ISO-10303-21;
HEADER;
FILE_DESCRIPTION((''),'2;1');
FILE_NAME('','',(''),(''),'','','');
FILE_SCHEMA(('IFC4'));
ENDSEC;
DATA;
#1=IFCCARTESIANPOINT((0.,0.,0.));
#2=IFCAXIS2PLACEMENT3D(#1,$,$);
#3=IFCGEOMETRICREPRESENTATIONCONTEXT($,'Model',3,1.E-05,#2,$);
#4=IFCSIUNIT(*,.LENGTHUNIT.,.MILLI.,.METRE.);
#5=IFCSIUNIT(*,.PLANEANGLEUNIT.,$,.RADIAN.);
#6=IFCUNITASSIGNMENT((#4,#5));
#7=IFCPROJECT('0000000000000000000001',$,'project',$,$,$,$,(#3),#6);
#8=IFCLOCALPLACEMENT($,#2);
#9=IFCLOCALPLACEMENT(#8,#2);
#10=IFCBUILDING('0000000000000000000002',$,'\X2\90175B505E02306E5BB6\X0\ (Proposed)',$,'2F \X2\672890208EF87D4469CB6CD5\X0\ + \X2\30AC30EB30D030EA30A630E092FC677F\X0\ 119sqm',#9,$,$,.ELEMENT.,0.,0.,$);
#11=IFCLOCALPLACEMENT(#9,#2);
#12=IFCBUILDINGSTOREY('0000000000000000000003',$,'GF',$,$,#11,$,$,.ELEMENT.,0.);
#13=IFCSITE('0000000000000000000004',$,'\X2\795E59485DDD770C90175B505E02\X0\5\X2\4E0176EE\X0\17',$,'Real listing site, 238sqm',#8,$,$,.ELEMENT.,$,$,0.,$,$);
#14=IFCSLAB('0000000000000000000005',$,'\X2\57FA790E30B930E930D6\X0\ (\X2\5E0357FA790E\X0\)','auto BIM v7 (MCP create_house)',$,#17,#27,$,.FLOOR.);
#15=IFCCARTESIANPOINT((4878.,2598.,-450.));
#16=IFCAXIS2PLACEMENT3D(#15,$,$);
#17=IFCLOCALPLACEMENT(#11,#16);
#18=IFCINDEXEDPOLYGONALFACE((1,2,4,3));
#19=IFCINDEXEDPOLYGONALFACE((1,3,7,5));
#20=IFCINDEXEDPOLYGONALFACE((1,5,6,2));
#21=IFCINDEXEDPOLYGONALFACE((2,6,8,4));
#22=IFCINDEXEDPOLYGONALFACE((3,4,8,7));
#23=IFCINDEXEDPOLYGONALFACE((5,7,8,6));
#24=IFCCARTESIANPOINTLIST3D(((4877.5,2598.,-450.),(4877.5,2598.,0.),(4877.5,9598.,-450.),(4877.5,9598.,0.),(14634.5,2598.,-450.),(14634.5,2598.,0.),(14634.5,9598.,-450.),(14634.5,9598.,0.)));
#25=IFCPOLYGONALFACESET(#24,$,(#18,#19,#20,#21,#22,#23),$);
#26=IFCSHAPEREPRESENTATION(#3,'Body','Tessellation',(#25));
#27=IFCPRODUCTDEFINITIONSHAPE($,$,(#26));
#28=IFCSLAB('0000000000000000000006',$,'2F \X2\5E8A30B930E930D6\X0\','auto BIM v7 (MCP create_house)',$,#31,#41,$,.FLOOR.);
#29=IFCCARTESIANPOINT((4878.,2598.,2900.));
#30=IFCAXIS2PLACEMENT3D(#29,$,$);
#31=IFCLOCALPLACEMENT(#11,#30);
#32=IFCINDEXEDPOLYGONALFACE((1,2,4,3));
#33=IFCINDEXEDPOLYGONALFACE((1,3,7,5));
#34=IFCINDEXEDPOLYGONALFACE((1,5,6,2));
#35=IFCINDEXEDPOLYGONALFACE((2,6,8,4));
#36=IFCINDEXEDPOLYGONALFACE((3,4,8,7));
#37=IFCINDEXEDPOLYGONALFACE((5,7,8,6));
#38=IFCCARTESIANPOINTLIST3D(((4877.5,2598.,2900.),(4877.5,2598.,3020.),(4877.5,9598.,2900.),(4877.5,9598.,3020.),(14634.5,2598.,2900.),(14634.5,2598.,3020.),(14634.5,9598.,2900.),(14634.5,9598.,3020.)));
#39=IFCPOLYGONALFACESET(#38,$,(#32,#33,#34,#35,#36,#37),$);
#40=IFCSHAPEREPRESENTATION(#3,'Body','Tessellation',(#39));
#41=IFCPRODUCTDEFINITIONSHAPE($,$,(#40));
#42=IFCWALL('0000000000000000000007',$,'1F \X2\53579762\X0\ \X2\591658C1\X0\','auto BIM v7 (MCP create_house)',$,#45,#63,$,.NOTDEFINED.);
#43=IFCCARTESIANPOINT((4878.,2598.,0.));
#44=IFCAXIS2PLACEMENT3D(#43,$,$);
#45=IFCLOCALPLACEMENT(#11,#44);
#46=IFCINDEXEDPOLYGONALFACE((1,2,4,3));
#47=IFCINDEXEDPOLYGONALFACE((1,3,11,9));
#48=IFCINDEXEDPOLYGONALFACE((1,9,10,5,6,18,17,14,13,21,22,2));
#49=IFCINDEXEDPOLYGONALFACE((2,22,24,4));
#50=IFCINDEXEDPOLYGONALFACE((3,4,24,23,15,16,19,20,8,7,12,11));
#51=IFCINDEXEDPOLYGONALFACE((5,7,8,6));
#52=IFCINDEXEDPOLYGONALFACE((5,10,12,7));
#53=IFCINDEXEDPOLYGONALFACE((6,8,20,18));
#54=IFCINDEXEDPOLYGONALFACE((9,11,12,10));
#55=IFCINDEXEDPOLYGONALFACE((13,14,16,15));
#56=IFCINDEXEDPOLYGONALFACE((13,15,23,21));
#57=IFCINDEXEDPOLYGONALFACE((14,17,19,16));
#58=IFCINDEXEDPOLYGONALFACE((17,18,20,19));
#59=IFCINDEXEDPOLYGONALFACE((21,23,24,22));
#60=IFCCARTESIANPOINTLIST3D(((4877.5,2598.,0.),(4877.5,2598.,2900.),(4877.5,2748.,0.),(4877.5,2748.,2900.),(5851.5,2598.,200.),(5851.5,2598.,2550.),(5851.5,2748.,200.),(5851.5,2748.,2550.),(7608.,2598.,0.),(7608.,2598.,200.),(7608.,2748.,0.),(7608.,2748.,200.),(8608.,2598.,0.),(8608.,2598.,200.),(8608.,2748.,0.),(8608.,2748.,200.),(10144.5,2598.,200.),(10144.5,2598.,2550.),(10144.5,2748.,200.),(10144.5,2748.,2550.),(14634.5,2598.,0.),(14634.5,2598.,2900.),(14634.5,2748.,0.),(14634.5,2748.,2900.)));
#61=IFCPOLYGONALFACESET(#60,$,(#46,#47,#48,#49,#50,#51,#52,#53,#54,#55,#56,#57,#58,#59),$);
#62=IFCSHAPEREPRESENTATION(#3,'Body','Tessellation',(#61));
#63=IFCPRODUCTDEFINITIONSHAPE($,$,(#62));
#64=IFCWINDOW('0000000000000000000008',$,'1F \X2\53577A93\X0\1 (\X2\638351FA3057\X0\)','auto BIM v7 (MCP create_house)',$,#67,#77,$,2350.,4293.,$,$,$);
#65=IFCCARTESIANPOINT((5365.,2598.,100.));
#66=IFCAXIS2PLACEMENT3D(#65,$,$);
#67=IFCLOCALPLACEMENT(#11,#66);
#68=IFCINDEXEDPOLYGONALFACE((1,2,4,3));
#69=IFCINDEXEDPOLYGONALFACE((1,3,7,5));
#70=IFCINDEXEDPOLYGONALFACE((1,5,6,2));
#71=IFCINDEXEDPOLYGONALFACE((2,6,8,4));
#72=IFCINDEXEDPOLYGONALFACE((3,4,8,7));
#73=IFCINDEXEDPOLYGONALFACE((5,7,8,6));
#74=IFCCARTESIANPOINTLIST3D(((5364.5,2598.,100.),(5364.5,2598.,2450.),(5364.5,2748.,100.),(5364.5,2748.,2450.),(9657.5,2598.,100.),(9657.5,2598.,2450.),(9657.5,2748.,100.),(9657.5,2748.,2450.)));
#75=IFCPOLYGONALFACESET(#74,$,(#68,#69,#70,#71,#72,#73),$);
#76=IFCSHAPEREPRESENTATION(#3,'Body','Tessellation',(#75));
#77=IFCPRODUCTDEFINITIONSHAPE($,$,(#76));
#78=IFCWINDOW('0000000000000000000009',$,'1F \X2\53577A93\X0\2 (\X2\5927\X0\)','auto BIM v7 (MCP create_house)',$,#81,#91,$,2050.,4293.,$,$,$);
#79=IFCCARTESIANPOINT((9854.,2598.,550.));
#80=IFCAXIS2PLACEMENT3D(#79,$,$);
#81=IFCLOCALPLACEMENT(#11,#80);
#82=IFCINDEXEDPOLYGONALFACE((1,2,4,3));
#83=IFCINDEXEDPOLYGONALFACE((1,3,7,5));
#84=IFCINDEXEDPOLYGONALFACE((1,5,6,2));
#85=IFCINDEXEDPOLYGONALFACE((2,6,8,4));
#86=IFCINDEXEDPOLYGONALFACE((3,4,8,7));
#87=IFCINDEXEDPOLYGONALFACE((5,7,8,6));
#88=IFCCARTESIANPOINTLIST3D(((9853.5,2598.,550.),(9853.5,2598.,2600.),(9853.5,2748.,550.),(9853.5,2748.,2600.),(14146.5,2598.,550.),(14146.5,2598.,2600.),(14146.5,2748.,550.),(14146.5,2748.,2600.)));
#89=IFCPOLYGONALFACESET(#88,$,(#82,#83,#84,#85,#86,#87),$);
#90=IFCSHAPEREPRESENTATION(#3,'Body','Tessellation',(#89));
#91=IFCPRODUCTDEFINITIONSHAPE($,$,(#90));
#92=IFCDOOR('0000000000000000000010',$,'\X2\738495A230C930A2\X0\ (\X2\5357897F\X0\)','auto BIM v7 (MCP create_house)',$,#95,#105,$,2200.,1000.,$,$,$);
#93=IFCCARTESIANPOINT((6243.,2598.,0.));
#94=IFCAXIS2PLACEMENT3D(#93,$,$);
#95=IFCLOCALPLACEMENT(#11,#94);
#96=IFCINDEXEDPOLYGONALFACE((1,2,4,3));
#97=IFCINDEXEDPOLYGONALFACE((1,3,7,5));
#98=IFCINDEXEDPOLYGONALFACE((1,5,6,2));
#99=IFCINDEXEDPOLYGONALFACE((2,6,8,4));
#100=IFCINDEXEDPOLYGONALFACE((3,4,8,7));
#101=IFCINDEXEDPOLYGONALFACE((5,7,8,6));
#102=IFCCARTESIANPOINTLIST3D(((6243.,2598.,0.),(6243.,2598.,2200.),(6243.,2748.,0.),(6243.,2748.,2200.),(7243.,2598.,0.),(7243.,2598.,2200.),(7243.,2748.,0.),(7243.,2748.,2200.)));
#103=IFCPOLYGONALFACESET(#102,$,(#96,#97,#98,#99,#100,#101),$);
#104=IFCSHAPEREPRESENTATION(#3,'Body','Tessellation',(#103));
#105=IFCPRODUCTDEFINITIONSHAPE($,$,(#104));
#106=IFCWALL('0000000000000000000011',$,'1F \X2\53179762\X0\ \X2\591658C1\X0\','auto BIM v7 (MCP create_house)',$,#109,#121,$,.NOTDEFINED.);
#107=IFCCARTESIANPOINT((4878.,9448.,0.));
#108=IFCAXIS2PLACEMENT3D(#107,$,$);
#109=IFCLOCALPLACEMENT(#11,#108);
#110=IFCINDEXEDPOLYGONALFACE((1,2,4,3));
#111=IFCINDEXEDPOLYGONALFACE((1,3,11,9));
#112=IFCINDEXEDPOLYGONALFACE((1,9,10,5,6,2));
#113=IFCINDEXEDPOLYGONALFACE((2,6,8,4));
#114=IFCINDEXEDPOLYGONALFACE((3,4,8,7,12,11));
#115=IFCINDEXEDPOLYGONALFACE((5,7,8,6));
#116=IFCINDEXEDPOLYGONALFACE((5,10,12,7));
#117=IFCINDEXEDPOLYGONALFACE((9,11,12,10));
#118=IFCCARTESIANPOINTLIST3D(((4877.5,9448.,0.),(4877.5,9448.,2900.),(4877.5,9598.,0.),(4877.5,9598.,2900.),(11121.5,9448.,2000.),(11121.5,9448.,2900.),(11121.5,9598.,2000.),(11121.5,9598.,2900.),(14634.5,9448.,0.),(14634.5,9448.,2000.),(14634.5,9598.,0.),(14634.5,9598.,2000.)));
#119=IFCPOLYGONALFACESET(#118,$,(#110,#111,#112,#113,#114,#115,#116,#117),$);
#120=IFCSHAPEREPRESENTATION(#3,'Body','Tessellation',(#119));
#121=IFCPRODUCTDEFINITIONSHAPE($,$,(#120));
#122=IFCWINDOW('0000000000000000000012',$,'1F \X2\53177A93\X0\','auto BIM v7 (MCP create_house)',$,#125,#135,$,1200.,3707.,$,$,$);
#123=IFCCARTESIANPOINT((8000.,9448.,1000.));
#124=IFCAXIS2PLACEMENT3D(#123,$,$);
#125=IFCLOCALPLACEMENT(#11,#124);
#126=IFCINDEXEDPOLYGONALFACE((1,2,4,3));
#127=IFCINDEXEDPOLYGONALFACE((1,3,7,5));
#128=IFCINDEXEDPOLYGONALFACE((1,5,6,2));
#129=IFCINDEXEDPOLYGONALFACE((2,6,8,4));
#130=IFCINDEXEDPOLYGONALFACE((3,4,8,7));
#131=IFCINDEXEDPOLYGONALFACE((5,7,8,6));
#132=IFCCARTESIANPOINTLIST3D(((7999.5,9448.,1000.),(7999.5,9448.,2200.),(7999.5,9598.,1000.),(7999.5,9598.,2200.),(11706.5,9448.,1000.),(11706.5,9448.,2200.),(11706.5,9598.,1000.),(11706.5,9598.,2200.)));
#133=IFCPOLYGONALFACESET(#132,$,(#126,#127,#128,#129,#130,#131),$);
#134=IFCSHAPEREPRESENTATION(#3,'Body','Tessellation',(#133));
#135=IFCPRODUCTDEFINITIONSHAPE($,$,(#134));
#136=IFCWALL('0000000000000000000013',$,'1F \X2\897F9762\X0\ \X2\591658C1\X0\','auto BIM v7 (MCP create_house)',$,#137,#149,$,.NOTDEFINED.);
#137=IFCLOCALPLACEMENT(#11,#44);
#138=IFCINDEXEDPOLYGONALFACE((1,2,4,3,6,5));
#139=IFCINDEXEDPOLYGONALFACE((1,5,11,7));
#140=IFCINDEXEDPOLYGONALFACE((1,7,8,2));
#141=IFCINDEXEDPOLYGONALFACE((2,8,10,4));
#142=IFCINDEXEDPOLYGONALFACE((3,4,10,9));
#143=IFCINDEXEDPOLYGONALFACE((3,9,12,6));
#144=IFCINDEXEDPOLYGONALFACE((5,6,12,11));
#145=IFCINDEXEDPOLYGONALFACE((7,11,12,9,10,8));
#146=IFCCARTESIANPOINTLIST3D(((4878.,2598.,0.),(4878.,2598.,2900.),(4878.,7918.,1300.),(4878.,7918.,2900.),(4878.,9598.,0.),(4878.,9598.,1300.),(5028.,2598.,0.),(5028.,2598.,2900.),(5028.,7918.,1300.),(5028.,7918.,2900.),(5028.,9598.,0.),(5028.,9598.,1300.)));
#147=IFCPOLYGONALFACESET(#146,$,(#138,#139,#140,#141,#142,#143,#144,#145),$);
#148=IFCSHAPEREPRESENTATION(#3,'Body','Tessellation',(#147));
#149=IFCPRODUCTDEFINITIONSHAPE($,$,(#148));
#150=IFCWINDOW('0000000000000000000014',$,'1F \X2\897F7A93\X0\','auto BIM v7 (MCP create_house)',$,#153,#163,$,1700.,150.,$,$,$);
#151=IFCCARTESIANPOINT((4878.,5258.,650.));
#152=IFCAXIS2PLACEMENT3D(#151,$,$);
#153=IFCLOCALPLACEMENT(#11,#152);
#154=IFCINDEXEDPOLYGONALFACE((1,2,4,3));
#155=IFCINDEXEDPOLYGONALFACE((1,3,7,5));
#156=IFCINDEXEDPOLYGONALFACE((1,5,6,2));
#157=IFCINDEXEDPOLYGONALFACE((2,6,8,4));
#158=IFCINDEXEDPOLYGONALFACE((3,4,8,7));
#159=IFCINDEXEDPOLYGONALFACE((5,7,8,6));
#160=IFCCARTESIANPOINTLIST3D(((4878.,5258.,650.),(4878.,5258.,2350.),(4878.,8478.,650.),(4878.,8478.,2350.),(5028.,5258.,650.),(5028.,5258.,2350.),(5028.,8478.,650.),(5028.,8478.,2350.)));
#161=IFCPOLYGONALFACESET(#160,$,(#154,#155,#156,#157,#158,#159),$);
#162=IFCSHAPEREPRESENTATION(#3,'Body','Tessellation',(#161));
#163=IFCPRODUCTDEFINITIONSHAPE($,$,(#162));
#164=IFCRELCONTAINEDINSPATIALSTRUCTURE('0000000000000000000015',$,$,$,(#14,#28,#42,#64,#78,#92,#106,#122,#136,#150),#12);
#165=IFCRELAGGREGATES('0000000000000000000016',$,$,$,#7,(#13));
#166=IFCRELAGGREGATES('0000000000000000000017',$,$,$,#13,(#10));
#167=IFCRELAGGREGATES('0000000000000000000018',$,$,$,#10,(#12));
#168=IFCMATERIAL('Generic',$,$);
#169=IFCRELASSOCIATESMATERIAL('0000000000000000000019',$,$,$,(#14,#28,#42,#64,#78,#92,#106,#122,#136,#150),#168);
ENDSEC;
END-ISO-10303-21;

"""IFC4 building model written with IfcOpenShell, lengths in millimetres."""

from ifc_helpers import new_model, si_unit, frame, frame_2d, origin, place, context, project, spatial, rectangle, extrude, material, element, fill, save


model = new_model("IFC4")

# Units and contexts
model_context = context("Model", 3, precision=1e-05, world=origin())
ifc_project = project(units=[si_unit("LENGTHUNIT", "METRE", prefix="MILLI"), si_unit("PLANEANGLEUNIT", "RADIAN")], contexts=[model_context])

# Site, building, storey
site_placement = place(None, origin())
site = spatial("IfcSite", under=ifc_project, at=site_placement, Name="神奈川県逗子市5丁目17", ObjectType="Real listing site, 238sqm", CompositionType="ELEMENT", RefElevation=0.0)
building_placement = place(site_placement, origin())
building = spatial("IfcBuilding", under=site, at=building_placement, Name="逗子市の家 (Proposed)", ObjectType="2F 木造軸組構法 + ガルバリウム鋼板 119sqm", CompositionType="ELEMENT", ElevationOfRefHeight=0.0, ElevationOfTerrain=0.0)
storey_placement = place(building_placement, origin())
storey = spatial("IfcBuildingStorey", under=building, at=storey_placement, Name="GF", CompositionType="ELEMENT", Elevation=0.0)

# Slabs
ifc_material = material(Name="Generic")
slab_1_placement = place(storey_placement, frame((4878.0, 2598.0, -450.0)))
element("IfcSlab", 1, at=slab_1_placement, inside=storey, material=ifc_material, Name="基礎スラブ (布基礎)", Description="auto BIM v7 (MCP create_house)", PredefinedType="FLOOR", context=model_context, shape_type="SweptSolid", body=[
    extrude(rectangle(XDim=9757.0, YDim=7000.0, at=frame_2d((4878.0, 3500.0))), frame((4878.0, 2598.0, -450.0)), (0.0, 0.0, 1.0), 450.0),
])
slab_2_placement = place(storey_placement, frame((4878.0, 2598.0, 2900.0)))
element("IfcSlab", 2, at=slab_2_placement, inside=storey, material=ifc_material, Name="2F 床スラブ", Description="auto BIM v7 (MCP create_house)", PredefinedType="FLOOR", context=model_context, shape_type="SweptSolid", body=[
    extrude(rectangle(XDim=9757.0, YDim=7000.0, at=frame_2d((4878.0, 3500.0))), frame((4878.0, 2598.0, 2900.0)), (0.0, 0.0, 1.0), 120.0),
])

# Wall, openings, windows, door
wall_1_placement = place(storey_placement, frame((4878.0, 2598.0, 0.0)))
wall_1 = element("IfcWall", 3, at=wall_1_placement, inside=storey, material=ifc_material, Name="1F 南面 外壁", Description="auto BIM v7 (MCP create_house)", PredefinedType="NOTDEFINED", context=model_context, shape_type="SweptSolid", body=[
    extrude(rectangle(XDim=9757.0, YDim=150.0, at=frame_2d((4878.0, 75.0))), frame((4878.0, 2598.0, 0.0)), (0.0, 0.0, 1.0), 2900.0),
])
opening_1_placement = place(storey_placement, frame((5365.0, 2598.0, 100.0)))
opening_1 = element("IfcOpeningElement", 4, at=opening_1_placement, cuts=wall_1, PredefinedType="NOTDEFINED", context=model_context, shape_type="SweptSolid", body=[
    extrude(rectangle(XDim=4293.0, YDim=150.0, at=frame_2d((2146.0, 75.0))), frame((5365.0, 2598.0, 100.0)), (0.0, 0.0, 1.0), 2350.0),
])
opening_2_placement = place(storey_placement, frame((9854.0, 2598.0, 550.0)))
opening_2 = element("IfcOpeningElement", 5, at=opening_2_placement, cuts=wall_1, PredefinedType="NOTDEFINED", context=model_context, shape_type="SweptSolid", body=[
    extrude(rectangle(XDim=4293.0, YDim=150.0, at=frame_2d((2146.0, 75.0))), frame((9854.0, 2598.0, 550.0)), (0.0, 0.0, 1.0), 2050.0),
])
opening_3_placement = place(storey_placement, frame((6243.0, 2598.0, 0.0)))
opening_3 = element("IfcOpeningElement", 6, at=opening_3_placement, cuts=wall_1, PredefinedType="NOTDEFINED", context=model_context, shape_type="SweptSolid", body=[
    extrude(rectangle(XDim=1000.0, YDim=150.0, at=frame_2d((500.0, 75.0))), frame((6243.0, 2598.0, 0.0)), (0.0, 0.0, 1.0), 2200.0),
])
window_1_placement = place(storey_placement, frame((5365.0, 2598.0, 100.0)))
window_1 = element("IfcWindow", 7, at=window_1_placement, inside=storey, material=ifc_material, Name="1F 南窓1 (掃出し)", Description="auto BIM v7 (MCP create_house)", OverallHeight=2350.0, OverallWidth=4293.0, context=model_context, shape_type="SweptSolid", body=[
    extrude(rectangle(XDim=4293.0, YDim=150.0, at=frame_2d((2146.0, 75.0))), frame((5365.0, 2598.0, 100.0)), (0.0, 0.0, 1.0), 2350.0),
])
fill(opening_1, window_1)
window_2_placement = place(storey_placement, frame((9854.0, 2598.0, 550.0)))
window_2 = element("IfcWindow", 8, at=window_2_placement, inside=storey, material=ifc_material, Name="1F 南窓2 (大)", Description="auto BIM v7 (MCP create_house)", OverallHeight=2050.0, OverallWidth=4293.0, context=model_context, shape_type="SweptSolid", body=[
    extrude(rectangle(XDim=4293.0, YDim=150.0, at=frame_2d((2146.0, 75.0))), frame((9854.0, 2598.0, 550.0)), (0.0, 0.0, 1.0), 2050.0),
])
fill(opening_2, window_2)
door_placement = place(storey_placement, frame((6243.0, 2598.0, 0.0)))
door = element("IfcDoor", 9, at=door_placement, inside=storey, material=ifc_material, Name="玄関ドア (南西)", Description="auto BIM v7 (MCP create_house)", OverallHeight=2200.0, OverallWidth=1000.0, context=model_context, shape_type="SweptSolid", body=[
    extrude(rectangle(XDim=1000.0, YDim=150.0, at=frame_2d((500.0, 75.0))), frame((6243.0, 2598.0, 0.0)), (0.0, 0.0, 1.0), 2200.0),
])
fill(opening_3, door)

# Walls, openings, windows
wall_2_placement = place(storey_placement, frame((4878.0, 9448.0, 0.0)))
wall_2 = element("IfcWall", 10, at=wall_2_placement, inside=storey, material=ifc_material, Name="1F 北面 外壁", Description="auto BIM v7 (MCP create_house)", PredefinedType="NOTDEFINED", context=model_context, shape_type="SweptSolid", body=[
    extrude(rectangle(XDim=9757.0, YDim=150.0, at=frame_2d((4878.0, 75.0))), frame((4878.0, 9448.0, 0.0)), (0.0, 0.0, 1.0), 2900.0),
])
opening_4_placement = place(storey_placement, frame((8000.0, 9448.0, 1000.0)))
opening_4 = element("IfcOpeningElement", 11, at=opening_4_placement, cuts=wall_2, PredefinedType="NOTDEFINED", context=model_context, shape_type="SweptSolid", body=[
    extrude(rectangle(XDim=3707.0, YDim=150.0, at=frame_2d((1853.0, 75.0))), frame((8000.0, 9448.0, 1000.0)), (0.0, 0.0, 1.0), 1200.0),
])
window_3_placement = place(storey_placement, frame((8000.0, 9448.0, 1000.0)))
window_3 = element("IfcWindow", 12, at=window_3_placement, inside=storey, material=ifc_material, Name="1F 北窓", Description="auto BIM v7 (MCP create_house)", OverallHeight=1200.0, OverallWidth=3707.0, context=model_context, shape_type="SweptSolid", body=[
    extrude(rectangle(XDim=3707.0, YDim=150.0, at=frame_2d((1853.0, 75.0))), frame((8000.0, 9448.0, 1000.0)), (0.0, 0.0, 1.0), 1200.0),
])
fill(opening_4, window_3)
wall_3_placement = place(storey_placement, frame((4878.0, 2598.0, 0.0)))
wall_3 = element("IfcWall", 13, at=wall_3_placement, inside=storey, material=ifc_material, Name="1F 西面 外壁", Description="auto BIM v7 (MCP create_house)", PredefinedType="NOTDEFINED", context=model_context, shape_type="SweptSolid", body=[
    extrude(rectangle(XDim=150.0, YDim=7000.0, at=frame_2d((75.0, 3500.0))), frame((4878.0, 2598.0, 0.0)), (0.0, 0.0, 1.0), 2900.0),
])
opening_5_placement = place(storey_placement, frame((4878.0, 5258.0, 650.0)))
opening_5 = element("IfcOpeningElement", 14, at=opening_5_placement, cuts=wall_3, PredefinedType="NOTDEFINED", context=model_context, shape_type="SweptSolid", body=[
    extrude(rectangle(XDim=150.0, YDim=3220.0, at=frame_2d((75.0, 1610.0))), frame((4878.0, 5258.0, 650.0)), (0.0, 0.0, 1.0), 1700.0),
])
window_4_placement = place(storey_placement, frame((4878.0, 5258.0, 650.0)))
window_4 = element("IfcWindow", 15, at=window_4_placement, inside=storey, material=ifc_material, Name="1F 西窓", Description="auto BIM v7 (MCP create_house)", OverallHeight=1700.0, OverallWidth=150.0, context=model_context, shape_type="SweptSolid", body=[
    extrude(rectangle(XDim=150.0, YDim=3220.0, at=frame_2d((75.0, 1610.0))), frame((4878.0, 5258.0, 650.0)), (0.0, 0.0, 1.0), 1700.0),
])
fill(opening_5, window_4)

save(model, "model.ifc")
